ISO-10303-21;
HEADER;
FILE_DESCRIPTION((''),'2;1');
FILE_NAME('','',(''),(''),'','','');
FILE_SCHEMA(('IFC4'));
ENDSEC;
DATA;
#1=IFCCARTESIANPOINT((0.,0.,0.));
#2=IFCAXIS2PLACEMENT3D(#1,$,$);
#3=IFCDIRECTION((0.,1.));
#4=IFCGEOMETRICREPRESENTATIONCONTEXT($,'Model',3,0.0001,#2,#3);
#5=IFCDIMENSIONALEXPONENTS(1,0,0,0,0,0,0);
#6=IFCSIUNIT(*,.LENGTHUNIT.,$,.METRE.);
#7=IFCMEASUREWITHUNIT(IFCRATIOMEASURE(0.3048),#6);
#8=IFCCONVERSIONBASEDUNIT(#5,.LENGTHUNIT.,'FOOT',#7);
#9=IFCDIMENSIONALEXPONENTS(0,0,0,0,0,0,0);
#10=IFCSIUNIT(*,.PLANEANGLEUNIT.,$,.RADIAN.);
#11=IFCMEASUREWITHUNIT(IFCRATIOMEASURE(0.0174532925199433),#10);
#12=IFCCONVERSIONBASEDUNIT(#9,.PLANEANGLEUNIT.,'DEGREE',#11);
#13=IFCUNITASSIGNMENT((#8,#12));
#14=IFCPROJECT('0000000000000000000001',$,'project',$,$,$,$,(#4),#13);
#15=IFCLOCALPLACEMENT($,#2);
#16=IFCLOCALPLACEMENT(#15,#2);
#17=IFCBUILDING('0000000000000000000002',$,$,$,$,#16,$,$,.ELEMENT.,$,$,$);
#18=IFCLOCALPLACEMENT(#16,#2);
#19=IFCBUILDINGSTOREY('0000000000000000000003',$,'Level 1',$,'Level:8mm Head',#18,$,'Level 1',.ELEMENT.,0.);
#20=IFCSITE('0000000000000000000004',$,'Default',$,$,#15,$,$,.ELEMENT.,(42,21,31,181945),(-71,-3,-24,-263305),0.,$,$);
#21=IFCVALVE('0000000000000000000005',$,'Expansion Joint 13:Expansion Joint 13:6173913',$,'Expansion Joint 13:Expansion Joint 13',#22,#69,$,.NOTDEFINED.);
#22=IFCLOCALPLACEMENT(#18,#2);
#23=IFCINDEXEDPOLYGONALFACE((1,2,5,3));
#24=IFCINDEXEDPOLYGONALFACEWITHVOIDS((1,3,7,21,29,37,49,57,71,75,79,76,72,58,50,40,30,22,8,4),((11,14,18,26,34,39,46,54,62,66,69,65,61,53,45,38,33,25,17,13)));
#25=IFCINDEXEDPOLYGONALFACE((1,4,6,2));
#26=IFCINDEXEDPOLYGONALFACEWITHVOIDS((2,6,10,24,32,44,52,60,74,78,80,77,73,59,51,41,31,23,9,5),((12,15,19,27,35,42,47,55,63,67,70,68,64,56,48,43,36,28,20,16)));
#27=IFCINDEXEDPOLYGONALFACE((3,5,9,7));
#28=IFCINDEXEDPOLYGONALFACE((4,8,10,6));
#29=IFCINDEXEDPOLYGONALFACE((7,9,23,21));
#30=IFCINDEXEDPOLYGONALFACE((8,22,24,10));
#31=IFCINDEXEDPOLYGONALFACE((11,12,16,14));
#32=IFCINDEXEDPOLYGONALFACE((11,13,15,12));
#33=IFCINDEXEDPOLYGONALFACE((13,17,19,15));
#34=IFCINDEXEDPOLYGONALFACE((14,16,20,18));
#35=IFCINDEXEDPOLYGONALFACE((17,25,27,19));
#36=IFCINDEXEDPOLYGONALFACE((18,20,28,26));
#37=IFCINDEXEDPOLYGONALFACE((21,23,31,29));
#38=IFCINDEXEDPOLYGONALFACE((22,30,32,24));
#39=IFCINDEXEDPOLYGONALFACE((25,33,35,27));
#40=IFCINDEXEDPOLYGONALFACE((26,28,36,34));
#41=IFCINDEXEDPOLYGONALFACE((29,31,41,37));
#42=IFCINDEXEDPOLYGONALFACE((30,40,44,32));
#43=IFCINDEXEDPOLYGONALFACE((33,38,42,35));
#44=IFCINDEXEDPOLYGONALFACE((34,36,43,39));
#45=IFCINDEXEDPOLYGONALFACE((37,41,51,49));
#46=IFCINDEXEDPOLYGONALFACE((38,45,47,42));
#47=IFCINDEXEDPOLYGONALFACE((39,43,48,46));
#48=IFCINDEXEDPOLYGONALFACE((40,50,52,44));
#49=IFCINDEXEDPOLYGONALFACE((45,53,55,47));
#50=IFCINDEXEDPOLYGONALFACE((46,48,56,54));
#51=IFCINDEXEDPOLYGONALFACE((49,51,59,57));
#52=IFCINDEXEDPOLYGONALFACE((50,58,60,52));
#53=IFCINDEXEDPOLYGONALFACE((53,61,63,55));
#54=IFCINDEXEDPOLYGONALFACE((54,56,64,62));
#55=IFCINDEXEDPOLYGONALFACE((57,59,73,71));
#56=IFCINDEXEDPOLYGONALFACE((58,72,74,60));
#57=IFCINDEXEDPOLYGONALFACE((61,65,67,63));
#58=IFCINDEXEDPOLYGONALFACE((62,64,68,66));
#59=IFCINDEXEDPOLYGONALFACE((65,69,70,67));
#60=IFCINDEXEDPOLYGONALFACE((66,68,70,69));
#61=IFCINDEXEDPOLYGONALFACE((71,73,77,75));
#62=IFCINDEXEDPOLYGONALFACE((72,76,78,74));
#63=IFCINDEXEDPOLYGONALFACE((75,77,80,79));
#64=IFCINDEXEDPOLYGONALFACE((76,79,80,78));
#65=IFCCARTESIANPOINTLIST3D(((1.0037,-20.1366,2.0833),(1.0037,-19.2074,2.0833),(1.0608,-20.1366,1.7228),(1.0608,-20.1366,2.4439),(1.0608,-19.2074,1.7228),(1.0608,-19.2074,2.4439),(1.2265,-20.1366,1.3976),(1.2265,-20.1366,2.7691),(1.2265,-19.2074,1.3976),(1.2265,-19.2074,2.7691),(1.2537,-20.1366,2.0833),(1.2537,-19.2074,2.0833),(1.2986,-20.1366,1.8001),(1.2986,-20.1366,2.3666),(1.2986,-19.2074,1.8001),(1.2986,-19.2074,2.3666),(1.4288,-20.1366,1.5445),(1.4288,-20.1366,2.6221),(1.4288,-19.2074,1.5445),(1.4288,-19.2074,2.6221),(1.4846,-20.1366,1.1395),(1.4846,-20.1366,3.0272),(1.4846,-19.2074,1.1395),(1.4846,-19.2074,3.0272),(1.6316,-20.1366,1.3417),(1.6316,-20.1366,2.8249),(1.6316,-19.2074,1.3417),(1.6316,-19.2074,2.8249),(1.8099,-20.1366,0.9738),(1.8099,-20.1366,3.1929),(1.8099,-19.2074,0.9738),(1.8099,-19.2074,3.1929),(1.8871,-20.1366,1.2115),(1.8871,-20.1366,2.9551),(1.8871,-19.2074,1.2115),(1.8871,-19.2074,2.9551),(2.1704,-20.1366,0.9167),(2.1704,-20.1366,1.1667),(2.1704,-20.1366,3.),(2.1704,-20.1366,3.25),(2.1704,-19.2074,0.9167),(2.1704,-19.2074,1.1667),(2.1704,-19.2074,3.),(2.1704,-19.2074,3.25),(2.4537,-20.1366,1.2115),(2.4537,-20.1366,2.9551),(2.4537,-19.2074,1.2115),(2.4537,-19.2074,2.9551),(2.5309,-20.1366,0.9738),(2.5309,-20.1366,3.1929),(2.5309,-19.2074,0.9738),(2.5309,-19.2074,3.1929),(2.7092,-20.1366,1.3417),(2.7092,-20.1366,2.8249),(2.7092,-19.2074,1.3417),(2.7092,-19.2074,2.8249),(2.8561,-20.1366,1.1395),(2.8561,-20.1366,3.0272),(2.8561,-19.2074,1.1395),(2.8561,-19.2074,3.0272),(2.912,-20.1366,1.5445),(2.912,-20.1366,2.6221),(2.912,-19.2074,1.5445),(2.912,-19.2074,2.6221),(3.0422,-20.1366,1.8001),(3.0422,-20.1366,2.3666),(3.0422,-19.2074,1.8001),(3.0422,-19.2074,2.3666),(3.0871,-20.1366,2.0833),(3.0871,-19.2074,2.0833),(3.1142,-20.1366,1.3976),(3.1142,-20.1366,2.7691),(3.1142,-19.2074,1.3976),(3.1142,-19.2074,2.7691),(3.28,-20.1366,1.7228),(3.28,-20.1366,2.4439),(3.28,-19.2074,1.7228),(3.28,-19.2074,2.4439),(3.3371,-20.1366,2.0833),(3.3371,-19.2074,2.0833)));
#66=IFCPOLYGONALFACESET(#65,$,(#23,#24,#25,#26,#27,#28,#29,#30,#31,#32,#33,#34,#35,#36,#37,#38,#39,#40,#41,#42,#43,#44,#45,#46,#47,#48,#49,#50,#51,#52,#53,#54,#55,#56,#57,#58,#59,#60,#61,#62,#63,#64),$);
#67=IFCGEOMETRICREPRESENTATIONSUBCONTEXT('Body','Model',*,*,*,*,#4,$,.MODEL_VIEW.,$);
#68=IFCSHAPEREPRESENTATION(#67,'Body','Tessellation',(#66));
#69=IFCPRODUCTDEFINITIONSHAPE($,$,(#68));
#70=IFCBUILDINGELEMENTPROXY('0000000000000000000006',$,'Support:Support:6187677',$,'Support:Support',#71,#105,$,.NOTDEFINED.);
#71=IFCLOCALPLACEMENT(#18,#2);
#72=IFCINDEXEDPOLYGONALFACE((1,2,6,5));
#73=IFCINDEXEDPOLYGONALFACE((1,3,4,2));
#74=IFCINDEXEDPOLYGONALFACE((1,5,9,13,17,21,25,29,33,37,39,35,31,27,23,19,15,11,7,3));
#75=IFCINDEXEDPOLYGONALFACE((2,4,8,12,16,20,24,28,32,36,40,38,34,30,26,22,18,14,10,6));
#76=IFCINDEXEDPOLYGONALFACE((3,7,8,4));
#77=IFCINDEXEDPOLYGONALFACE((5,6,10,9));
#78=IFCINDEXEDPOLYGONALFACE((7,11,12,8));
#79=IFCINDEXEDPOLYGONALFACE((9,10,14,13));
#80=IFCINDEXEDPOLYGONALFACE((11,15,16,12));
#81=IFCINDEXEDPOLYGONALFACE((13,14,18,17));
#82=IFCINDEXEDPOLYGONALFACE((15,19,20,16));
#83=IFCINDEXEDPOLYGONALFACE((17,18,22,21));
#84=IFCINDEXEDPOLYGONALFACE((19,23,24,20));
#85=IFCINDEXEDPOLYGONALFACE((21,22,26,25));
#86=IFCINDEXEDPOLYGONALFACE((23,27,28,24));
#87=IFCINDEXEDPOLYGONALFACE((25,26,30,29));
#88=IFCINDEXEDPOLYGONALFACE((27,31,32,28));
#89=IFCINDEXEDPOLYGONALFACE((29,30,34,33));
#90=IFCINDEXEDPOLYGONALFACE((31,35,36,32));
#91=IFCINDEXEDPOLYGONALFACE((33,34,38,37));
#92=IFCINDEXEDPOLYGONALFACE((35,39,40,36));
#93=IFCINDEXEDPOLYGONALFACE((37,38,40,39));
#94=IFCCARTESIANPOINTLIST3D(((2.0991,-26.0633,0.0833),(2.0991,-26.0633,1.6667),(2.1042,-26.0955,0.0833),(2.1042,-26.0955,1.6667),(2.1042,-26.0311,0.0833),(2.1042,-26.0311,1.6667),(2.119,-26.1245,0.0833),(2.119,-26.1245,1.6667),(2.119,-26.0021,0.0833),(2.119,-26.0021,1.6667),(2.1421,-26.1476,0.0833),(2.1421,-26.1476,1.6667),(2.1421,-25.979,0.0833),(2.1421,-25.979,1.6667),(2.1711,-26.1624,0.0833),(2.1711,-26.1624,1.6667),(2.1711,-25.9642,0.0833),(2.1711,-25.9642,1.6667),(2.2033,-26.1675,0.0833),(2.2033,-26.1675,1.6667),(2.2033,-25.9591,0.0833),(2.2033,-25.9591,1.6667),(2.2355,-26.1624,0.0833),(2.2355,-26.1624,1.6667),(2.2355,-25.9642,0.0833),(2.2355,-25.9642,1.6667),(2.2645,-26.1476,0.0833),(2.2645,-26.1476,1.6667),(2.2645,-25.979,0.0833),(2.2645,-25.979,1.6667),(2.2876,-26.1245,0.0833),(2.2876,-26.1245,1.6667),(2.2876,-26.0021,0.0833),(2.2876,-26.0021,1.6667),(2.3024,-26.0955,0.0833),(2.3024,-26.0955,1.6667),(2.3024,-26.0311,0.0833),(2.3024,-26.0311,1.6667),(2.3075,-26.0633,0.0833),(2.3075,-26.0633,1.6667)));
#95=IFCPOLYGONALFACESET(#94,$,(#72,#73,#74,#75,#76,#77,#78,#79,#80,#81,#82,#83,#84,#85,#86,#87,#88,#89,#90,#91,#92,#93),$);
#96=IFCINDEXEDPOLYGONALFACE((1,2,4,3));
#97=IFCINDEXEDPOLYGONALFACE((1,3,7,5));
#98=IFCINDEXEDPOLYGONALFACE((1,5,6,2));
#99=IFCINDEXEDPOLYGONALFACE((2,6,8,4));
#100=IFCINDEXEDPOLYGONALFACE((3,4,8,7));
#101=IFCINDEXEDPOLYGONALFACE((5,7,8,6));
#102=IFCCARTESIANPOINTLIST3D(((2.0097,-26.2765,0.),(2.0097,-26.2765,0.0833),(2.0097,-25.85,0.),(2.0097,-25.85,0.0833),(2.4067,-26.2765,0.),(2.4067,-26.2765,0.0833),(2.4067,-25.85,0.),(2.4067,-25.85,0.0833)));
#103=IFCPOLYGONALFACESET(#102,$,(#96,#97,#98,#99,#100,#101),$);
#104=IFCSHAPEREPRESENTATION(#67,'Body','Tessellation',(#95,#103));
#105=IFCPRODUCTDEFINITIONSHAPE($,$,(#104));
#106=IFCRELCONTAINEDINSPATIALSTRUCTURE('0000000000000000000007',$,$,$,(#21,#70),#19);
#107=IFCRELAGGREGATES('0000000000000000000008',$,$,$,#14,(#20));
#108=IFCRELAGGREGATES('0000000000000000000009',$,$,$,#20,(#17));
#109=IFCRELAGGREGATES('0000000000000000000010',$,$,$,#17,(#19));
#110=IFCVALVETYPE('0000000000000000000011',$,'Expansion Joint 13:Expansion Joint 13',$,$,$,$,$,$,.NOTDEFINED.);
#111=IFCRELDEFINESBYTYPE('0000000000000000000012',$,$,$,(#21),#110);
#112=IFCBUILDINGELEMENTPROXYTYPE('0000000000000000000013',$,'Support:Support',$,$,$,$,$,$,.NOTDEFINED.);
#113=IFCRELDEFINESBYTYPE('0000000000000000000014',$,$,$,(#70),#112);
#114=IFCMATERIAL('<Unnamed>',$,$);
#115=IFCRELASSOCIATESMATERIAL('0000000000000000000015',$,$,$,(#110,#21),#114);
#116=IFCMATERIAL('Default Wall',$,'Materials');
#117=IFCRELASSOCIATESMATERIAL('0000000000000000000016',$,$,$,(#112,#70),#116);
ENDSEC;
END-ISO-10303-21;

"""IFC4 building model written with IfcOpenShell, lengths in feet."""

from ifc_helpers import new_model, entity, si_unit, converted_unit, direction, frame, origin, place, context, subcontext, project, spatial, indexed_curve, outline, extrude, source, transform, mapped, material, type_object, type_shapes, element, save


model = new_model("IFC4")

# Units and contexts
model_context = context("Model", 3, precision=0.0001, world=origin(), true_north=direction((0.0, 1.0)))
body_context = subcontext(model_context, "Body", "Model", "MODEL_VIEW")
ifc_project = project(units=[converted_unit("LENGTHUNIT", "FOOT", entity("IfcRatioMeasure", 0.3048), si_unit("LENGTHUNIT", "METRE"), dimensions=[1, 0, 0, 0, 0, 0, 0]), converted_unit("PLANEANGLEUNIT", "DEGREE", entity("IfcRatioMeasure", 0.0174532925199433), si_unit("PLANEANGLEUNIT", "RADIAN"), dimensions=[0, 0, 0, 0, 0, 0, 0])], contexts=[model_context])

# Site, building, storey
site_placement = place(None, origin())
site = spatial("IfcSite", under=ifc_project, at=site_placement, Name="Default", CompositionType="ELEMENT", RefLatitude=(42, 21, 31, 181945), RefLongitude=(-71, -3, -24, -263305), RefElevation=0.0)
building_placement = place(site_placement, origin())
building = spatial("IfcBuilding", under=site, at=building_placement, CompositionType="ELEMENT")
storey_placement = place(building_placement, origin())
storey = spatial("IfcBuildingStorey", under=building, at=storey_placement, Name="Level 1", ObjectType="Level:8mm Head", LongName="Level 1", CompositionType="ELEMENT", Elevation=0.0)

# Valve
ifc_material_1 = material(Name="<Unnamed>")
valve_type_1 = type_object("IfcValveType", Name="Expansion Joint 13:Expansion Joint 13", PredefinedType="NOTDEFINED", material=ifc_material_1)
shared_shape_1 = source(origin(), body_context, "Body", "SweptSolid", [
    extrude(outline(indexed_curve([(1.1667, 0.0), (1.1096, 0.3605), (0.9439, 0.6857), (0.6857, 0.9439), (0.3605, 1.1096), (0.0, 1.1667), (-0.3605, 1.1096), (-0.6857, 0.9439), (-0.9439, 0.6857), (-1.1096, 0.3605), (-1.1667, 0.0), (-1.1096, -0.3605), (-0.9439, -0.6857), (-0.6857, -0.9439), (-0.3605, -1.1096), (0.0, -1.1667), (0.3605, -1.1096), (0.6857, -0.9439), (0.9439, -0.6857), (1.1096, -0.3605), (1.1667, 0.0)], self_intersect=False), holes=[indexed_curve([(0.9167, 0.0), (0.8718, -0.2833), (0.7416, -0.5388), (0.5388, -0.7416), (0.2833, -0.8718), (0.0, -0.9167), (-0.2833, -0.8718), (-0.5388, -0.7416), (-0.7416, -0.5388), (-0.8718, -0.2833), (-0.9167, 0.0), (-0.8718, 0.2833), (-0.7416, 0.5388), (-0.5388, 0.7416), (-0.2833, 0.8718), (0.0, 0.9167), (0.2833, 0.8718), (0.5388, 0.7416), (0.7416, 0.5388), (0.8718, 0.2833), (0.9167, 0.0)], self_intersect=False)]), frame((0.0, -0.4646, 1.1667), z_axis=(0.0, 1.0, 0.0), x_axis=(-1.0, 0.0, 0.0)), (0.0, 0.0, 1.0), 0.9292),
])
type_shapes(valve_type_1, [shared_shape_1])
valve_1_placement = place(storey_placement, frame((2.1704, -19.672, 0.9167)))
element("IfcValve", 1, at=valve_1_placement, inside=storey, type_object=valve_type_1, material=ifc_material_1, Name="Expansion Joint 13:Expansion Joint 13:6173913", ObjectType="Expansion Joint 13:Expansion Joint 13", PredefinedType="NOTDEFINED", context=body_context, shape_type="MappedRepresentation", body=[
    mapped(shared_shape_1, transform((0.0, 0.0, 0.0), scale=1.0)),
])

# Building element proxy
ifc_material_2 = material(Name="Default Wall", Category="Materials")
building_element_proxy_type = type_object("IfcBuildingElementProxyType", Name="Support:Support", PredefinedType="NOTDEFINED", material=ifc_material_2)
shared_shape_2 = source(origin(), body_context, "Body", "SweptSolid", [
    extrude(outline(indexed_curve([(0.1042, 0.0), (0.0991, 0.0322), (0.0843, 0.0612), (0.0612, 0.0843), (0.0322, 0.0991), (0.0, 0.1042), (-0.0322, 0.0991), (-0.0612, 0.0843), (-0.0843, 0.0612), (-0.0991, 0.0322), (-0.1042, 0.0), (-0.0991, -0.0322), (-0.0843, -0.0612), (-0.0612, -0.0843), (-0.0322, -0.0991), (0.0, -0.1042), (0.0322, -0.0991), (0.0612, -0.0843), (0.0843, -0.0612), (0.0991, -0.0322), (0.1042, 0.0)], self_intersect=False)), frame((-0.0049, 0.0, 0.0833)), (0.0, 0.0, 1.0), 1.5833),
    extrude(outline(indexed_curve([(-0.1985, -0.2133), (0.1985, -0.2133), (0.1985, 0.2133), (-0.1985, 0.2133), (-0.1985, -0.2133)], self_intersect=False)), frame((0.0, 0.0, 0.0), z_axis=(0.0, 0.0, 1.0), x_axis=(-1.0, 0.0, 0.0)), (0.0, 0.0, 1.0), 0.0833),
])
type_shapes(building_element_proxy_type, [shared_shape_2])
proxy_placement = place(storey_placement, frame((2.2082, -26.0633, 0.0)))
element("IfcBuildingElementProxy", 2, at=proxy_placement, inside=storey, type_object=building_element_proxy_type, material=ifc_material_2, Name="Support:Support:6187677", ObjectType="Support:Support", PredefinedType="NOTDEFINED", context=body_context, shape_type="MappedRepresentation", body=[
    mapped(shared_shape_2, transform((0.0, 0.0, 0.0), scale=1.0)),
])

save(model, "model.ifc")
